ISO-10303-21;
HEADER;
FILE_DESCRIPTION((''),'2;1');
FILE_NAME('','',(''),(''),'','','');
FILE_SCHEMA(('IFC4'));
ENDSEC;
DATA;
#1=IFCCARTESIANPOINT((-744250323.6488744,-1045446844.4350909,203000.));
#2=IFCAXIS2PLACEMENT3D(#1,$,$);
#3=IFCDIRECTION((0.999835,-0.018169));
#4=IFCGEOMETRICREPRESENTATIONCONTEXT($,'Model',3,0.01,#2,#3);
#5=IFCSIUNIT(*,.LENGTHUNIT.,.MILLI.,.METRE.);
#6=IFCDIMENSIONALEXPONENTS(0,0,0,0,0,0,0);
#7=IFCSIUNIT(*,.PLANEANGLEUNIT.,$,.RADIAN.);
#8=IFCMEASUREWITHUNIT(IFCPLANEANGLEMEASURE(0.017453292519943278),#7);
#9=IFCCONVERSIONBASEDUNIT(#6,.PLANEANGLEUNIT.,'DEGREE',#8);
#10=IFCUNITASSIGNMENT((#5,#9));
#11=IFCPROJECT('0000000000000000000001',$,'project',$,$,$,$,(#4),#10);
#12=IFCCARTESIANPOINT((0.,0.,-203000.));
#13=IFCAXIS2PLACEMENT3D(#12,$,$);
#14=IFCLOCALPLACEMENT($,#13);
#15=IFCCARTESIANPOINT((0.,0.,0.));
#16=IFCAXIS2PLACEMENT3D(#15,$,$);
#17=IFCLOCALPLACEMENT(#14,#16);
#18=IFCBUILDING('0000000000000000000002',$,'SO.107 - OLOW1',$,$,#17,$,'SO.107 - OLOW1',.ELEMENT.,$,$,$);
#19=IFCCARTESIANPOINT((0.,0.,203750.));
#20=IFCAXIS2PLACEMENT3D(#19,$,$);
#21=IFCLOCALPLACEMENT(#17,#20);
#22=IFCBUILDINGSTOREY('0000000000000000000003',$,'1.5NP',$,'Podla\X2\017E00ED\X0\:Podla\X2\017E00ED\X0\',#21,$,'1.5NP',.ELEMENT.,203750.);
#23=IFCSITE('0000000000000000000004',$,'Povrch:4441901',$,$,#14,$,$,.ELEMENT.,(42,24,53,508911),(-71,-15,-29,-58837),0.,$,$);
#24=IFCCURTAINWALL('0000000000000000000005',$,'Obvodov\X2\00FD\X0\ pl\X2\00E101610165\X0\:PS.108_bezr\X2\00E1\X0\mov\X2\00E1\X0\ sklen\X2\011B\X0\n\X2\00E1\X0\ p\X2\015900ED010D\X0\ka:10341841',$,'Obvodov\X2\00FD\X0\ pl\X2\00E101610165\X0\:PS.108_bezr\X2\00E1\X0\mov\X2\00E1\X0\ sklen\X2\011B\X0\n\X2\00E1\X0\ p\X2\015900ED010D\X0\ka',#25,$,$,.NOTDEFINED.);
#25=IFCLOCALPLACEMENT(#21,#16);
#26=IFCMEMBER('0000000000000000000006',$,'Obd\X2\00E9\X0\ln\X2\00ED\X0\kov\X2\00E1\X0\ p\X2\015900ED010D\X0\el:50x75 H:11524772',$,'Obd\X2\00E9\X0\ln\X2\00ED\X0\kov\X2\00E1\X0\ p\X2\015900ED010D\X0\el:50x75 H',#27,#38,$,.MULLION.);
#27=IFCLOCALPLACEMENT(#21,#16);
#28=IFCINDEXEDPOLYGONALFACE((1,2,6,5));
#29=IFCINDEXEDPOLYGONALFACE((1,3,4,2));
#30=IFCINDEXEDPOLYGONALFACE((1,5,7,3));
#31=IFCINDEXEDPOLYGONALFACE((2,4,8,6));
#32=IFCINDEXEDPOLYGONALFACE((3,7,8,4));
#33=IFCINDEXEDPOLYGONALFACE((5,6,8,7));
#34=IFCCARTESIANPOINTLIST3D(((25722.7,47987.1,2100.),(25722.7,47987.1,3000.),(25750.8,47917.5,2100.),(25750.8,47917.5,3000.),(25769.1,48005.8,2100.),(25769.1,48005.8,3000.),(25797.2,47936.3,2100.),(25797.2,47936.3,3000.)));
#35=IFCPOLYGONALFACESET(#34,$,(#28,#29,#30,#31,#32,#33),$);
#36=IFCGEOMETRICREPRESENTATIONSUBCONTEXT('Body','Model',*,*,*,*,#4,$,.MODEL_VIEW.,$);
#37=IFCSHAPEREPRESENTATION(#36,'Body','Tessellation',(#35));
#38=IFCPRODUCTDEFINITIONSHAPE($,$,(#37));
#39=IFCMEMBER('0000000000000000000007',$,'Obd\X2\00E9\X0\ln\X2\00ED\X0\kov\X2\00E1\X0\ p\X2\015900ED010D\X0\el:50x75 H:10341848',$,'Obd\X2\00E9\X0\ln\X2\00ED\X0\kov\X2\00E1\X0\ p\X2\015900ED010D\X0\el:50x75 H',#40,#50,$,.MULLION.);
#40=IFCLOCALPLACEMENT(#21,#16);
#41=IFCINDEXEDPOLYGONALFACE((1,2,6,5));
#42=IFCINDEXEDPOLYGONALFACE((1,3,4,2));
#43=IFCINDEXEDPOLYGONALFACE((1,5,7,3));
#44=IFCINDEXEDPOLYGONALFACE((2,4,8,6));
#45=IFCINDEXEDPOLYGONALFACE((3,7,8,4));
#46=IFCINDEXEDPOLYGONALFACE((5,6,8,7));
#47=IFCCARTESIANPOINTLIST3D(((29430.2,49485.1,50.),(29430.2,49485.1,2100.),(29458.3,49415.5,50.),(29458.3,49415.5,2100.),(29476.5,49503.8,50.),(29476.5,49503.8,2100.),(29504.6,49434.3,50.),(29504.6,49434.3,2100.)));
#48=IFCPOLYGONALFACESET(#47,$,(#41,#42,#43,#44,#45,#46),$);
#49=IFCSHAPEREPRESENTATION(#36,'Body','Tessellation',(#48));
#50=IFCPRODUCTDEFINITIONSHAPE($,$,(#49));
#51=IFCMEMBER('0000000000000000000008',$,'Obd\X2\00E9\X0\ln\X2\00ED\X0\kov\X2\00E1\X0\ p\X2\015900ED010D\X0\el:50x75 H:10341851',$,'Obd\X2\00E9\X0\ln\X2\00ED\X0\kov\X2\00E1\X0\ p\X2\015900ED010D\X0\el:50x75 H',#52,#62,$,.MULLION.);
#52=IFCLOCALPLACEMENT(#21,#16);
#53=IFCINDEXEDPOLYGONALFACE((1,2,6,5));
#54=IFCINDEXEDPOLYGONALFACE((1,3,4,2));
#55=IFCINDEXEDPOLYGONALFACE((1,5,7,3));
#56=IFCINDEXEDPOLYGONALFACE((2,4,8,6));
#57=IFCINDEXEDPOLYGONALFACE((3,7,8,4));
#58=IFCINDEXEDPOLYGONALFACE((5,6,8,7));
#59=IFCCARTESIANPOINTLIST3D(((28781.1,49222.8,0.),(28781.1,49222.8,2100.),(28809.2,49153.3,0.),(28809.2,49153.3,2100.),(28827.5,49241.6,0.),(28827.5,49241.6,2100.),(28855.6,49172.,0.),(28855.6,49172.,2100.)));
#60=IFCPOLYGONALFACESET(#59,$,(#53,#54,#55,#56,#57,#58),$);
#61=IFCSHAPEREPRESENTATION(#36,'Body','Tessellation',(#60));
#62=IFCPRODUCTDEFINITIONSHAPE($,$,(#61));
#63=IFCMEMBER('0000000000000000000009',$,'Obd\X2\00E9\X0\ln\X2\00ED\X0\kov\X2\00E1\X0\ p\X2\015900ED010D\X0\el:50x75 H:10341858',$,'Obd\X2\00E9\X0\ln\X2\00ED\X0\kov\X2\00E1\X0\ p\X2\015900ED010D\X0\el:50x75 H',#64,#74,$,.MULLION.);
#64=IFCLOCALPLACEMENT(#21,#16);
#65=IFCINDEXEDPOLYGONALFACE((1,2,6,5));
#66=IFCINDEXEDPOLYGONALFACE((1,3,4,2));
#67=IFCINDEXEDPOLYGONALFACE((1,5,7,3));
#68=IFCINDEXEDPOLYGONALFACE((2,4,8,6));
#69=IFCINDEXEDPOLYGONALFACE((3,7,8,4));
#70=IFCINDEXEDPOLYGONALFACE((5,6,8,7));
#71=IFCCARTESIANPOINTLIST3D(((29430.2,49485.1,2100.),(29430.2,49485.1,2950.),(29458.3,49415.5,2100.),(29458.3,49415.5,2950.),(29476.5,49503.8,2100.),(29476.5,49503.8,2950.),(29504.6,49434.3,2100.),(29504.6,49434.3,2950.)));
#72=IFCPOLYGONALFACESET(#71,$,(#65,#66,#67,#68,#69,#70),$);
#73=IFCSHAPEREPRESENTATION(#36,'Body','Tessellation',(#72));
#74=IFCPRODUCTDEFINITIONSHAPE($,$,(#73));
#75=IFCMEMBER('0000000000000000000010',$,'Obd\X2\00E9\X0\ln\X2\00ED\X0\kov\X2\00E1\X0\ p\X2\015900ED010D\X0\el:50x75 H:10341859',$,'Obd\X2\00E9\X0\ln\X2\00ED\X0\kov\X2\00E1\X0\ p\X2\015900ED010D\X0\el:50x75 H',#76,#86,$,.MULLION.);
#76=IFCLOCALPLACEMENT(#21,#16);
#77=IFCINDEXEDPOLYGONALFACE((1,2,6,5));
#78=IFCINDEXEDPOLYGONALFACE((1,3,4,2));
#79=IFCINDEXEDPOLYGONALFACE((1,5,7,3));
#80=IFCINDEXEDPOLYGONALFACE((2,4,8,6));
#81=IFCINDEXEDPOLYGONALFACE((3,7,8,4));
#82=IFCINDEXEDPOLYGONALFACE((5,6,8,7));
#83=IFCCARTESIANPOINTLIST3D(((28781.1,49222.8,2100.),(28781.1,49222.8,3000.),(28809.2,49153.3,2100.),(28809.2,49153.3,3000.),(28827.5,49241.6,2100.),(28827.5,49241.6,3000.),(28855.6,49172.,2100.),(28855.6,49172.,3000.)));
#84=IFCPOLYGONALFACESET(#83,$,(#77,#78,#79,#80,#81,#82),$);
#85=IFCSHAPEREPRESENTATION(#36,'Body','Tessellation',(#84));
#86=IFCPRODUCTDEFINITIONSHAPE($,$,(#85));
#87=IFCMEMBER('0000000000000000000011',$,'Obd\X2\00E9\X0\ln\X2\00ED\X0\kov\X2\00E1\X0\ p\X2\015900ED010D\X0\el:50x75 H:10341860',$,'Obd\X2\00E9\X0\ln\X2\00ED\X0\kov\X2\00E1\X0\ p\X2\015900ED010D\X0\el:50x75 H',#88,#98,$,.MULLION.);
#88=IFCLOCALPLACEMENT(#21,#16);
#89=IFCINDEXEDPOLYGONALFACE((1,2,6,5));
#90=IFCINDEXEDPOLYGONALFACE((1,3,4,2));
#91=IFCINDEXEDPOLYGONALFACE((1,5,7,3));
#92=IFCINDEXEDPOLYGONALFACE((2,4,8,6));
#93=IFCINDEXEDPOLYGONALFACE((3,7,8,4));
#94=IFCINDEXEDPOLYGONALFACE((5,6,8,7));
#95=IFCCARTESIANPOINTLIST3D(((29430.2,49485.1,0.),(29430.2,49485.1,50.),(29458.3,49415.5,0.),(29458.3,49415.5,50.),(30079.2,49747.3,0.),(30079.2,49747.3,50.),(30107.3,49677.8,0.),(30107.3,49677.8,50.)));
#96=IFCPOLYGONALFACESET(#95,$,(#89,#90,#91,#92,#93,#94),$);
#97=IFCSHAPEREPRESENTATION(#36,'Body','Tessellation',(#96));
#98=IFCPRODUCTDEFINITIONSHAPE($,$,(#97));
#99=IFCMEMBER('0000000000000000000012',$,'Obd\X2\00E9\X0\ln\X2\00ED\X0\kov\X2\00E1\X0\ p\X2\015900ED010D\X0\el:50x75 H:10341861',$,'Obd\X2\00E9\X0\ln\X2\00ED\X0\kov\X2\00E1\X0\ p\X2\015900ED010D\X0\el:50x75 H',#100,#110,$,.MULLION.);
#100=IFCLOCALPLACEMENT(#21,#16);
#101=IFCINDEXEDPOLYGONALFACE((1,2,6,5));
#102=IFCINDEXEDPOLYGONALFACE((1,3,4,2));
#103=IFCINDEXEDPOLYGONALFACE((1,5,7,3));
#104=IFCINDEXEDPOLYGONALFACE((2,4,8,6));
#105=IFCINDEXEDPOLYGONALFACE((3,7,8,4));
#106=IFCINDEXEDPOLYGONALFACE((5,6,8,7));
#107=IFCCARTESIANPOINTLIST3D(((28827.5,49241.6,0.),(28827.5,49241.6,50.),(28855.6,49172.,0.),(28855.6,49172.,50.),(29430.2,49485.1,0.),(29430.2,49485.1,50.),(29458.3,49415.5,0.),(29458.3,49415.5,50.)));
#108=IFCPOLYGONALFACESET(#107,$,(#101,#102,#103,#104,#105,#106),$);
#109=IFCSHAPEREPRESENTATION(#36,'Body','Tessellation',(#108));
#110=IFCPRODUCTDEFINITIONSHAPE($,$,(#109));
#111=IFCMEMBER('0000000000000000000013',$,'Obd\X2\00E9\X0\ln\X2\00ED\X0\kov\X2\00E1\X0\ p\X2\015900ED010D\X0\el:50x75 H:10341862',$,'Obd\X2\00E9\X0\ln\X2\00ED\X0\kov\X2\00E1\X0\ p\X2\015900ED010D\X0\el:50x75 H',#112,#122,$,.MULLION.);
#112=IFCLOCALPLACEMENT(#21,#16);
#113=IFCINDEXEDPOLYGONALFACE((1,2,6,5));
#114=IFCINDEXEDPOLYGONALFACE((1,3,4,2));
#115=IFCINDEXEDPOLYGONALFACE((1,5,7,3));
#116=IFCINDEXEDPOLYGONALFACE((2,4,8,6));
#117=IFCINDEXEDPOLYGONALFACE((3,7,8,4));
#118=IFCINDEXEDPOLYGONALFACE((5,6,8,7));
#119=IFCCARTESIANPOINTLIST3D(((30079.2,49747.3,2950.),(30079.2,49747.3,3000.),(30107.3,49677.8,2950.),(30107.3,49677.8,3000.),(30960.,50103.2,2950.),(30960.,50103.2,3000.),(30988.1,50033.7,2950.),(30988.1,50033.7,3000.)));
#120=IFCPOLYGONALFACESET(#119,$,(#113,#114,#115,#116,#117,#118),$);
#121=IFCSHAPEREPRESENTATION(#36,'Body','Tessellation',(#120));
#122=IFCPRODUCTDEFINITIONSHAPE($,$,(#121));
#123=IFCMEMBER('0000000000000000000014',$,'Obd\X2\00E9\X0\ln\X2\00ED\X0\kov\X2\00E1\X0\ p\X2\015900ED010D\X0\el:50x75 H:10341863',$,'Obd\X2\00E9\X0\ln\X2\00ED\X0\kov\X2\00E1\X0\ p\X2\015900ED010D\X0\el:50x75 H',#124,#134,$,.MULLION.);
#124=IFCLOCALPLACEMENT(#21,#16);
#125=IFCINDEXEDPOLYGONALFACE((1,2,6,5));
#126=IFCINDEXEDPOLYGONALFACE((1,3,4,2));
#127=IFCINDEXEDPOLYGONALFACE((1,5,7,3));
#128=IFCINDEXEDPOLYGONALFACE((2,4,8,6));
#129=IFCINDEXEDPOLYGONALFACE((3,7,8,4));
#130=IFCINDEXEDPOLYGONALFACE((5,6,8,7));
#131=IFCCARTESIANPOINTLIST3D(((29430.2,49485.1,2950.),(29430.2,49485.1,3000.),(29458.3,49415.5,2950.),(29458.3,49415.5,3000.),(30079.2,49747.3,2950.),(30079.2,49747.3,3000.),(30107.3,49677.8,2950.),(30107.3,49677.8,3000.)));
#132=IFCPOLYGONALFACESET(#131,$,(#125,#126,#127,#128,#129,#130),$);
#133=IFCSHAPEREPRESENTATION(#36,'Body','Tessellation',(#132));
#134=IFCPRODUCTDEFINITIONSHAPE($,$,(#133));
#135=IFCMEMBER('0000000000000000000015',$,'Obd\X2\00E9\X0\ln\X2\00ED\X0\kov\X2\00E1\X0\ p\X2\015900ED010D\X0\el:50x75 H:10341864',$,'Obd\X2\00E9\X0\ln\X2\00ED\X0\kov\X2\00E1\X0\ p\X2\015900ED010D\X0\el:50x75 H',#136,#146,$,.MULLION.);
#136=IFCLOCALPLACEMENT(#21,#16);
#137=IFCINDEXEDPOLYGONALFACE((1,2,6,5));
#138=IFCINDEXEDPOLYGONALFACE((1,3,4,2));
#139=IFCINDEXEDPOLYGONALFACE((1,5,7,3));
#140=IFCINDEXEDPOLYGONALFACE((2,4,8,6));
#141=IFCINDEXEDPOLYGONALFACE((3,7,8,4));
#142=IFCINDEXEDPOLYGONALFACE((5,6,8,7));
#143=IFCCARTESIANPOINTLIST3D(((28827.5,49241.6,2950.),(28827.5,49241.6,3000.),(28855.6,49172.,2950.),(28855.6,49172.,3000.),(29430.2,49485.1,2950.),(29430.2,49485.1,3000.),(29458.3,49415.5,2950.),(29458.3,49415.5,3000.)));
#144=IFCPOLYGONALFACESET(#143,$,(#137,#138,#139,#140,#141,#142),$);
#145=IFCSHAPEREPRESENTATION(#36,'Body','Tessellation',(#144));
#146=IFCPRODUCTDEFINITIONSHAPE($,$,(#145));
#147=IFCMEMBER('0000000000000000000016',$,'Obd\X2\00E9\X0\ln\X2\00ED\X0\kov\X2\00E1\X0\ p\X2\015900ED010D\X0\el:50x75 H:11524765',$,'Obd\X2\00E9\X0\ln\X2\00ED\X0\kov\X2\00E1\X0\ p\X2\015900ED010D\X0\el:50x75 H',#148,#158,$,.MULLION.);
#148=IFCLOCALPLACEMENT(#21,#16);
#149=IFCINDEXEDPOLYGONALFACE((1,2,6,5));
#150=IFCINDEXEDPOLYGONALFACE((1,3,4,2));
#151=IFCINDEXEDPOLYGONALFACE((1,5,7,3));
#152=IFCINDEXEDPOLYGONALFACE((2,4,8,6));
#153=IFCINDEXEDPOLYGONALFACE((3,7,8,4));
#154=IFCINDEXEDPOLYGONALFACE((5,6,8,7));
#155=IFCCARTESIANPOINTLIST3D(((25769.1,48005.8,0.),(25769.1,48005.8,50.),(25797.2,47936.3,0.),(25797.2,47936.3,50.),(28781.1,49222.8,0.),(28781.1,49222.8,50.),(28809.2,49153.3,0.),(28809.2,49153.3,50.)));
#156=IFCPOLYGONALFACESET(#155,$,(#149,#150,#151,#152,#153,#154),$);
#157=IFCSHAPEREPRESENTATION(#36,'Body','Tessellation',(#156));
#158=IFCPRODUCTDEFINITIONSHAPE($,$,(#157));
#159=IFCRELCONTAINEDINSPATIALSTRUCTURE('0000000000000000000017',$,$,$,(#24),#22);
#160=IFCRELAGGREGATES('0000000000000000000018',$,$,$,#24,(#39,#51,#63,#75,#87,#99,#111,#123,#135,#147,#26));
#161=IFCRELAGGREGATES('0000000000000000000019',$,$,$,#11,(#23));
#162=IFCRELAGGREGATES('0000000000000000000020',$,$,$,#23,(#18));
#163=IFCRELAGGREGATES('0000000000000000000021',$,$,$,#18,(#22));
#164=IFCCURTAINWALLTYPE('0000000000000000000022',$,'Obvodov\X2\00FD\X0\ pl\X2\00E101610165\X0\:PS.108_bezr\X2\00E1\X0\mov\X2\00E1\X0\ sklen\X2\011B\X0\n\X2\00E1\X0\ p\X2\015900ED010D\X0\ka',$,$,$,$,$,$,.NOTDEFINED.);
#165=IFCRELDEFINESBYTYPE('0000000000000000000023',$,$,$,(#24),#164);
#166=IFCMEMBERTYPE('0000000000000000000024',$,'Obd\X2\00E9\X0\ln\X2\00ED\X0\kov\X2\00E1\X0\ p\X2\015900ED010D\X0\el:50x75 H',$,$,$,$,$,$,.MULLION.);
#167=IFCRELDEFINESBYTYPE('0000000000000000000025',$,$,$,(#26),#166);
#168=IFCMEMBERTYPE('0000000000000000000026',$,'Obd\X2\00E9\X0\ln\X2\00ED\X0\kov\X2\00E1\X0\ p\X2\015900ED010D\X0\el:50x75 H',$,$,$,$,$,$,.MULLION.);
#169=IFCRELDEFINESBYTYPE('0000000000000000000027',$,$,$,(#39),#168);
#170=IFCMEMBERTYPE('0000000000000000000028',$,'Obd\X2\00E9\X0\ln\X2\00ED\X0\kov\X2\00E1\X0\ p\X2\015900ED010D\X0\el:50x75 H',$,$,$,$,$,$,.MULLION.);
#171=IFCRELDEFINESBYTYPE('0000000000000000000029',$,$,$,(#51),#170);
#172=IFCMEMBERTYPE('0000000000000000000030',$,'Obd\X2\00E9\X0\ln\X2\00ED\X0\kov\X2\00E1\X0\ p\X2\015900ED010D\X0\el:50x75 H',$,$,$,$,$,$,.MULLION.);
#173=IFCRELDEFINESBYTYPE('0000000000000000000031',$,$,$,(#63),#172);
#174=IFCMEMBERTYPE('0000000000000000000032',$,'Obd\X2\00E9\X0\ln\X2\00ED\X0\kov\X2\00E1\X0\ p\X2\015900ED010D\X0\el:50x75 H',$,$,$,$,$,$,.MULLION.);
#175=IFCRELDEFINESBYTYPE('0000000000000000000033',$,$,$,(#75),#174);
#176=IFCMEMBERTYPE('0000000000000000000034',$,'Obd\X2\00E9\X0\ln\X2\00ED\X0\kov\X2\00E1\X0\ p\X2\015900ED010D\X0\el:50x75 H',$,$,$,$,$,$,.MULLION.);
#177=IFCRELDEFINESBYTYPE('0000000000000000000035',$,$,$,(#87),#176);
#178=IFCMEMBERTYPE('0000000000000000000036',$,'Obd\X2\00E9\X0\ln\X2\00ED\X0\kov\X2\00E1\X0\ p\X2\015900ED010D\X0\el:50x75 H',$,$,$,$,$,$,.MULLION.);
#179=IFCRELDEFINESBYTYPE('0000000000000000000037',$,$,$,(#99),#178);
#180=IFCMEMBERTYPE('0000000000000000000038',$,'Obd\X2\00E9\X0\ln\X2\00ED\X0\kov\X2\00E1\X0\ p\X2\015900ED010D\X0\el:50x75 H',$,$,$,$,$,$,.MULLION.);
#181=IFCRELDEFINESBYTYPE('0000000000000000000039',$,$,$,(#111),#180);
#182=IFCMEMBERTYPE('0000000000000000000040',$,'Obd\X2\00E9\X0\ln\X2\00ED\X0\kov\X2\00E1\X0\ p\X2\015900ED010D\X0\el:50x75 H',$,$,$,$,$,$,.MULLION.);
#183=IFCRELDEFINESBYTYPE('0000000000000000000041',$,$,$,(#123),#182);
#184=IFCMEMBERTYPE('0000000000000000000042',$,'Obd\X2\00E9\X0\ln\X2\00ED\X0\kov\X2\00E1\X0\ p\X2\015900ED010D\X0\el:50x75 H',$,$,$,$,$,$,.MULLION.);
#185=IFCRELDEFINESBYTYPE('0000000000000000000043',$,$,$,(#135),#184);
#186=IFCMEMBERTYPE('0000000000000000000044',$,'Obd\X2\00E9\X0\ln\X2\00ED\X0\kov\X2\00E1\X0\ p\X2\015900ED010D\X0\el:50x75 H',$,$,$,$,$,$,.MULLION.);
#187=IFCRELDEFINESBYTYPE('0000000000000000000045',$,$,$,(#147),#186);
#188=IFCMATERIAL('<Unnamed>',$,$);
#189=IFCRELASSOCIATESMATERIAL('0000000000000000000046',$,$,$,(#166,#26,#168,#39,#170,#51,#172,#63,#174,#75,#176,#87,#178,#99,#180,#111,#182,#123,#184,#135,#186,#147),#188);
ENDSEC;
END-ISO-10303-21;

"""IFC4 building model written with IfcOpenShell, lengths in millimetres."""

from ifc_helpers import new_model, entity, si_unit, converted_unit, direction, frame, origin, place, context, subcontext, project, spatial, indexed_curve, outline, extrude, source, transform, mapped, material, type_object, type_shapes, element, aggregate, save


model = new_model("IFC4")

# Units and contexts
model_context = context("Model", 3, precision=0.01, world=frame((-744250323.6488744, -1045446844.4350909, 203000.0)), true_north=direction((0.999835, -0.018169)))
body_context = subcontext(model_context, "Body", "Model", "MODEL_VIEW")
ifc_project = project(units=[si_unit("LENGTHUNIT", "METRE", prefix="MILLI"), converted_unit("PLANEANGLEUNIT", "DEGREE", entity("IfcPlaneAngleMeasure", 0.017453292519943278), si_unit("PLANEANGLEUNIT", "RADIAN"), dimensions=[0, 0, 0, 0, 0, 0, 0])], contexts=[model_context])

# Site, building, storey
site_placement = place(None, frame((0.0, 0.0, -203000.0)))
site = spatial("IfcSite", under=ifc_project, at=site_placement, Name="Povrch:4441901", CompositionType="ELEMENT", RefLatitude=(42, 24, 53, 508911), RefLongitude=(-71, -15, -29, -58837), RefElevation=0.0)
building_placement = place(site_placement, origin())
building = spatial("IfcBuilding", under=site, at=building_placement, Name="SO.107 - OLOW1", LongName="SO.107 - OLOW1", CompositionType="ELEMENT")
storey_placement = place(building_placement, frame((0.0, 0.0, 203750.0)))
storey = spatial("IfcBuildingStorey", under=building, at=storey_placement, Name="1.5NP", ObjectType="Podlaží:Podlaží", LongName="1.5NP", CompositionType="ELEMENT", Elevation=203750.0)

# Curtain wall, members
ifc_material_1 = material(Name="<Unnamed>")
curtain_wall_type_1 = type_object("IfcCurtainWallType", Name="Obvodový plášť:PS.108_bezrámová skleněná příčka", PredefinedType="NOTDEFINED")
curtain_wall_1_placement = place(storey_placement, frame((0.0, 0.0, -203750.0)))
curtain_wall_1 = element("IfcCurtainWall", 1, at=curtain_wall_1_placement, inside=storey, type_object=curtain_wall_type_1, Name="Obvodový plášť:PS.108_bezrámová skleněná příčka:10341841", ObjectType="Obvodový plášť:PS.108_bezrámová skleněná příčka", PredefinedType="NOTDEFINED")
member_type_1 = type_object("IfcMemberType", Name="Obdélníková příčel:50x75 H", PredefinedType="MULLION", material=ifc_material_1)
shared_shape_1 = source(origin(), body_context, "Body", "SweptSolid", [
    extrude(outline(indexed_curve([(-25.0, -37.5), (25.0, -37.5), (25.0, 37.5), (-25.0, 37.5), (-25.0, -37.5)], self_intersect=False)), frame((-25.0, -37.5, -900.0), z_axis=(0.0, 0.0, 1.0), x_axis=(-1.0, 0.0, 0.0)), (0.0, 0.0, 1.0), 900.0),
])
type_shapes(member_type_1, [shared_shape_1])
member_1_placement = place(curtain_wall_1_placement, frame((25722.7, 47987.1, 205850.0), z_axis=(0.0, 0.0, -1.0), x_axis=(-0.927176, -0.374626, 0.0)))
member_1 = element("IfcMember", 2, at=member_1_placement, type_object=member_type_1, material=ifc_material_1, Name="Obdélníková příčel:50x75 H:11524772", ObjectType="Obdélníková příčel:50x75 H", PredefinedType="MULLION", context=body_context, shape_type="MappedRepresentation", body=[
    mapped(shared_shape_1, transform((0.0, 0.0, 0.0), scale=1.0)),
])
member_type_2 = type_object("IfcMemberType", Name="Obdélníková příčel:50x75 H", PredefinedType="MULLION", material=ifc_material_1)
shared_shape_2 = source(origin(), body_context, "Body", "SweptSolid", [
    extrude(outline(indexed_curve([(-25.0, -37.5), (25.0, -37.5), (25.0, 37.5), (-25.0, 37.5), (-25.0, -37.5)], self_intersect=False)), frame((-25.0, -37.5, -2050.0), z_axis=(0.0, 0.0, 1.0), x_axis=(-1.0, 0.0, 0.0)), (0.0, 0.0, 1.0), 2050.0),
])
type_shapes(member_type_2, [shared_shape_2])
member_2_placement = place(curtain_wall_1_placement, frame((29430.2, 49485.1, 203800.0), z_axis=(0.0, 0.0, -1.0), x_axis=(-0.927176, -0.374626, 0.0)))
member_2 = element("IfcMember", 3, at=member_2_placement, type_object=member_type_2, material=ifc_material_1, Name="Obdélníková příčel:50x75 H:10341848", ObjectType="Obdélníková příčel:50x75 H", PredefinedType="MULLION", context=body_context, shape_type="MappedRepresentation", body=[
    mapped(shared_shape_2, transform((0.0, 0.0, 0.0), scale=1.0)),
])
member_type_3 = type_object("IfcMemberType", Name="Obdélníková příčel:50x75 H", PredefinedType="MULLION", material=ifc_material_1)
shared_shape_3 = source(origin(), body_context, "Body", "SweptSolid", [
    extrude(outline(indexed_curve([(-25.0, -37.5), (25.0, -37.5), (25.0, 37.5), (-25.0, 37.5), (-25.0, -37.5)], self_intersect=False)), frame((-25.0, -37.5, -2100.0), z_axis=(0.0, 0.0, 1.0), x_axis=(-1.0, 0.0, 0.0)), (0.0, 0.0, 1.0), 2100.0),
])
type_shapes(member_type_3, [shared_shape_3])
member_3_placement = place(curtain_wall_1_placement, frame((28781.1, 49222.8, 203750.0), z_axis=(0.0, 0.0, -1.0), x_axis=(-0.927176, -0.374626, 0.0)))
member_3 = element("IfcMember", 4, at=member_3_placement, type_object=member_type_3, material=ifc_material_1, Name="Obdélníková příčel:50x75 H:10341851", ObjectType="Obdélníková příčel:50x75 H", PredefinedType="MULLION", context=body_context, shape_type="MappedRepresentation", body=[
    mapped(shared_shape_3, transform((0.0, 0.0, 0.0), scale=1.0)),
])
member_type_4 = type_object("IfcMemberType", Name="Obdélníková příčel:50x75 H", PredefinedType="MULLION", material=ifc_material_1)
shared_shape_4 = source(origin(), body_context, "Body", "SweptSolid", [
    extrude(outline(indexed_curve([(-25.0, -37.5), (25.0, -37.5), (25.0, 37.5), (-25.0, 37.5), (-25.0, -37.5)], self_intersect=False)), frame((-25.0, -37.5, -850.0), z_axis=(0.0, 0.0, 1.0), x_axis=(-1.0, 0.0, 0.0)), (0.0, 0.0, 1.0), 850.0),
])
type_shapes(member_type_4, [shared_shape_4])
member_4_placement = place(curtain_wall_1_placement, frame((29430.2, 49485.1, 205850.0), z_axis=(0.0, 0.0, -1.0), x_axis=(-0.927176, -0.374626, 0.0)))
member_4 = element("IfcMember", 5, at=member_4_placement, type_object=member_type_4, material=ifc_material_1, Name="Obdélníková příčel:50x75 H:10341858", ObjectType="Obdélníková příčel:50x75 H", PredefinedType="MULLION", context=body_context, shape_type="MappedRepresentation", body=[
    mapped(shared_shape_4, transform((0.0, 0.0, 0.0), scale=1.0)),
])
member_type_5 = type_object("IfcMemberType", Name="Obdélníková příčel:50x75 H", PredefinedType="MULLION", material=ifc_material_1)
shared_shape_5 = source(origin(), body_context, "Body", "SweptSolid", [
    extrude(outline(indexed_curve([(-25.0, -37.5), (25.0, -37.5), (25.0, 37.5), (-25.0, 37.5), (-25.0, -37.5)], self_intersect=False)), frame((-25.0, -37.5, -900.0), z_axis=(0.0, 0.0, 1.0), x_axis=(-1.0, 0.0, 0.0)), (0.0, 0.0, 1.0), 900.0),
])
type_shapes(member_type_5, [shared_shape_5])
member_5_placement = place(curtain_wall_1_placement, frame((28781.1, 49222.8, 205850.0), z_axis=(0.0, 0.0, -1.0), x_axis=(-0.927176, -0.374626, 0.0)))
member_5 = element("IfcMember", 6, at=member_5_placement, type_object=member_type_5, material=ifc_material_1, Name="Obdélníková příčel:50x75 H:10341859", ObjectType="Obdélníková příčel:50x75 H", PredefinedType="MULLION", context=body_context, shape_type="MappedRepresentation", body=[
    mapped(shared_shape_5, transform((0.0, 0.0, 0.0), scale=1.0)),
])
member_type_6 = type_object("IfcMemberType", Name="Obdélníková příčel:50x75 H", PredefinedType="MULLION", material=ifc_material_1)
shared_shape_6 = source(origin(), body_context, "Body", "SweptSolid", [
    extrude(outline(indexed_curve([(-25.0, -37.5), (25.0, -37.5), (25.0, 37.5), (-25.0, 37.5), (-25.0, -37.5)], self_intersect=False)), frame((-25.0, -37.5, -700.0), z_axis=(0.0, 0.0, 1.0), x_axis=(-1.0, 0.0, 0.0)), (0.0, 0.0, 1.0), 700.0),
])
type_shapes(member_type_6, [shared_shape_6])
member_6_placement = place(curtain_wall_1_placement, frame((30079.2, 49747.3, 203750.0), z_axis=(0.927176, 0.374626, 0.0), x_axis=(0.0, 0.0, -1.0)))
member_6 = element("IfcMember", 7, at=member_6_placement, type_object=member_type_6, material=ifc_material_1, Name="Obdélníková příčel:50x75 H:10341860", ObjectType="Obdélníková příčel:50x75 H", PredefinedType="MULLION", context=body_context, shape_type="MappedRepresentation", body=[
    mapped(shared_shape_6, transform((0.0, 0.0, 0.0), scale=1.0)),
])
member_type_7 = type_object("IfcMemberType", Name="Obdélníková příčel:50x75 H", PredefinedType="MULLION", material=ifc_material_1)
shared_shape_7 = source(origin(), body_context, "Body", "SweptSolid", [
    extrude(outline(indexed_curve([(-25.0, -37.5), (25.0, -37.5), (25.0, 37.5), (-25.0, 37.5), (-25.0, -37.5)], self_intersect=False)), frame((-25.0, -37.5, -650.0), z_axis=(0.0, 0.0, 1.0), x_axis=(-1.0, 0.0, 0.0)), (0.0, 0.0, 1.0), 650.0),
])
type_shapes(member_type_7, [shared_shape_7])
member_7_placement = place(curtain_wall_1_placement, frame((29430.2, 49485.1, 203750.0), z_axis=(0.927176, 0.374626, 0.0), x_axis=(0.0, 0.0, -1.0)))
member_7 = element("IfcMember", 8, at=member_7_placement, type_object=member_type_7, material=ifc_material_1, Name="Obdélníková příčel:50x75 H:10341861", ObjectType="Obdélníková příčel:50x75 H", PredefinedType="MULLION", context=body_context, shape_type="MappedRepresentation", body=[
    mapped(shared_shape_7, transform((0.0, 0.0, 0.0), scale=1.0)),
])
member_type_8 = type_object("IfcMemberType", Name="Obdélníková příčel:50x75 H", PredefinedType="MULLION", material=ifc_material_1)
shared_shape_8 = source(origin(), body_context, "Body", "SweptSolid", [
    extrude(outline(indexed_curve([(-25.0, -37.5), (25.0, -37.5), (25.0, 37.5), (-25.0, 37.5), (-25.0, -37.5)], self_intersect=False)), frame((-25.0, -37.5, -950.0), z_axis=(0.0, 0.0, 1.0), x_axis=(-1.0, 0.0, 0.0)), (0.0, 0.0, 1.0), 950.0),
])
type_shapes(member_type_8, [shared_shape_8])
member_8_placement = place(curtain_wall_1_placement, frame((30079.2, 49747.3, 206750.0), z_axis=(-0.927176, -0.374626, 0.0), x_axis=(0.0, 0.0, 1.0)))
member_8 = element("IfcMember", 9, at=member_8_placement, type_object=member_type_8, material=ifc_material_1, Name="Obdélníková příčel:50x75 H:10341862", ObjectType="Obdélníková příčel:50x75 H", PredefinedType="MULLION", context=body_context, shape_type="MappedRepresentation", body=[
    mapped(shared_shape_8, transform((0.0, 0.0, 0.0), scale=1.0)),
])
member_type_9 = type_object("IfcMemberType", Name="Obdélníková příčel:50x75 H", PredefinedType="MULLION", material=ifc_material_1)
shared_shape_9 = source(origin(), body_context, "Body", "SweptSolid", [
    extrude(outline(indexed_curve([(-25.0, -37.5), (25.0, -37.5), (25.0, 37.5), (-25.0, 37.5), (-25.0, -37.5)], self_intersect=False)), frame((-25.0, -37.5, -700.0), z_axis=(0.0, 0.0, 1.0), x_axis=(-1.0, 0.0, 0.0)), (0.0, 0.0, 1.0), 700.0),
])
type_shapes(member_type_9, [shared_shape_9])
member_9_placement = place(curtain_wall_1_placement, frame((29430.2, 49485.1, 206750.0), z_axis=(-0.927176, -0.374626, 0.0), x_axis=(0.0, 0.0, 1.0)))
member_9 = element("IfcMember", 10, at=member_9_placement, type_object=member_type_9, material=ifc_material_1, Name="Obdélníková příčel:50x75 H:10341863", ObjectType="Obdélníková příčel:50x75 H", PredefinedType="MULLION", context=body_context, shape_type="MappedRepresentation", body=[
    mapped(shared_shape_9, transform((0.0, 0.0, 0.0), scale=1.0)),
])
member_type_10 = type_object("IfcMemberType", Name="Obdélníková příčel:50x75 H", PredefinedType="MULLION", material=ifc_material_1)
shared_shape_10 = source(origin(), body_context, "Body", "SweptSolid", [
    extrude(outline(indexed_curve([(-25.0, -37.5), (25.0, -37.5), (25.0, 37.5), (-25.0, 37.5), (-25.0, -37.5)], self_intersect=False)), frame((-25.0, -37.5, -650.0), z_axis=(0.0, 0.0, 1.0), x_axis=(-1.0, 0.0, 0.0)), (0.0, 0.0, 1.0), 650.0),
])
type_shapes(member_type_10, [shared_shape_10])
member_10_placement = place(curtain_wall_1_placement, frame((28827.5, 49241.6, 206750.0), z_axis=(-0.927176, -0.374626, 0.0), x_axis=(0.0, 0.0, 1.0)))
member_10 = element("IfcMember", 11, at=member_10_placement, type_object=member_type_10, material=ifc_material_1, Name="Obdélníková příčel:50x75 H:10341864", ObjectType="Obdélníková příčel:50x75 H", PredefinedType="MULLION", context=body_context, shape_type="MappedRepresentation", body=[
    mapped(shared_shape_10, transform((0.0, 0.0, 0.0), scale=1.0)),
])
member_type_11 = type_object("IfcMemberType", Name="Obdélníková příčel:50x75 H", PredefinedType="MULLION", material=ifc_material_1)
shared_shape_11 = source(origin(), body_context, "Body", "SweptSolid", [
    extrude(outline(indexed_curve([(-25.0, -37.5), (25.0, -37.5), (25.0, 37.5), (-25.0, 37.5), (-25.0, -37.5)], self_intersect=False)), frame((-25.0, -37.5, -3248.6), z_axis=(0.0, 0.0, 1.0), x_axis=(-1.0, 0.0, 0.0)), (0.0, 0.0, 1.0), 3248.6),
])
type_shapes(member_type_11, [shared_shape_11])
member_11_placement = place(curtain_wall_1_placement, frame((28781.1, 49222.8, 203750.0), z_axis=(0.927176, 0.374626, 0.0), x_axis=(0.0, 0.0, -1.0)))
member_11 = element("IfcMember", 12, at=member_11_placement, type_object=member_type_11, material=ifc_material_1, Name="Obdélníková příčel:50x75 H:11524765", ObjectType="Obdélníková příčel:50x75 H", PredefinedType="MULLION", context=body_context, shape_type="MappedRepresentation", body=[
    mapped(shared_shape_11, transform((0.0, 0.0, 0.0), scale=1.0)),
])

aggregate(curtain_wall_1, [member_2, member_3, member_4, member_5, member_6, member_7, member_8, member_9, member_10, member_11, member_1])

save(model, "model.ifc")
